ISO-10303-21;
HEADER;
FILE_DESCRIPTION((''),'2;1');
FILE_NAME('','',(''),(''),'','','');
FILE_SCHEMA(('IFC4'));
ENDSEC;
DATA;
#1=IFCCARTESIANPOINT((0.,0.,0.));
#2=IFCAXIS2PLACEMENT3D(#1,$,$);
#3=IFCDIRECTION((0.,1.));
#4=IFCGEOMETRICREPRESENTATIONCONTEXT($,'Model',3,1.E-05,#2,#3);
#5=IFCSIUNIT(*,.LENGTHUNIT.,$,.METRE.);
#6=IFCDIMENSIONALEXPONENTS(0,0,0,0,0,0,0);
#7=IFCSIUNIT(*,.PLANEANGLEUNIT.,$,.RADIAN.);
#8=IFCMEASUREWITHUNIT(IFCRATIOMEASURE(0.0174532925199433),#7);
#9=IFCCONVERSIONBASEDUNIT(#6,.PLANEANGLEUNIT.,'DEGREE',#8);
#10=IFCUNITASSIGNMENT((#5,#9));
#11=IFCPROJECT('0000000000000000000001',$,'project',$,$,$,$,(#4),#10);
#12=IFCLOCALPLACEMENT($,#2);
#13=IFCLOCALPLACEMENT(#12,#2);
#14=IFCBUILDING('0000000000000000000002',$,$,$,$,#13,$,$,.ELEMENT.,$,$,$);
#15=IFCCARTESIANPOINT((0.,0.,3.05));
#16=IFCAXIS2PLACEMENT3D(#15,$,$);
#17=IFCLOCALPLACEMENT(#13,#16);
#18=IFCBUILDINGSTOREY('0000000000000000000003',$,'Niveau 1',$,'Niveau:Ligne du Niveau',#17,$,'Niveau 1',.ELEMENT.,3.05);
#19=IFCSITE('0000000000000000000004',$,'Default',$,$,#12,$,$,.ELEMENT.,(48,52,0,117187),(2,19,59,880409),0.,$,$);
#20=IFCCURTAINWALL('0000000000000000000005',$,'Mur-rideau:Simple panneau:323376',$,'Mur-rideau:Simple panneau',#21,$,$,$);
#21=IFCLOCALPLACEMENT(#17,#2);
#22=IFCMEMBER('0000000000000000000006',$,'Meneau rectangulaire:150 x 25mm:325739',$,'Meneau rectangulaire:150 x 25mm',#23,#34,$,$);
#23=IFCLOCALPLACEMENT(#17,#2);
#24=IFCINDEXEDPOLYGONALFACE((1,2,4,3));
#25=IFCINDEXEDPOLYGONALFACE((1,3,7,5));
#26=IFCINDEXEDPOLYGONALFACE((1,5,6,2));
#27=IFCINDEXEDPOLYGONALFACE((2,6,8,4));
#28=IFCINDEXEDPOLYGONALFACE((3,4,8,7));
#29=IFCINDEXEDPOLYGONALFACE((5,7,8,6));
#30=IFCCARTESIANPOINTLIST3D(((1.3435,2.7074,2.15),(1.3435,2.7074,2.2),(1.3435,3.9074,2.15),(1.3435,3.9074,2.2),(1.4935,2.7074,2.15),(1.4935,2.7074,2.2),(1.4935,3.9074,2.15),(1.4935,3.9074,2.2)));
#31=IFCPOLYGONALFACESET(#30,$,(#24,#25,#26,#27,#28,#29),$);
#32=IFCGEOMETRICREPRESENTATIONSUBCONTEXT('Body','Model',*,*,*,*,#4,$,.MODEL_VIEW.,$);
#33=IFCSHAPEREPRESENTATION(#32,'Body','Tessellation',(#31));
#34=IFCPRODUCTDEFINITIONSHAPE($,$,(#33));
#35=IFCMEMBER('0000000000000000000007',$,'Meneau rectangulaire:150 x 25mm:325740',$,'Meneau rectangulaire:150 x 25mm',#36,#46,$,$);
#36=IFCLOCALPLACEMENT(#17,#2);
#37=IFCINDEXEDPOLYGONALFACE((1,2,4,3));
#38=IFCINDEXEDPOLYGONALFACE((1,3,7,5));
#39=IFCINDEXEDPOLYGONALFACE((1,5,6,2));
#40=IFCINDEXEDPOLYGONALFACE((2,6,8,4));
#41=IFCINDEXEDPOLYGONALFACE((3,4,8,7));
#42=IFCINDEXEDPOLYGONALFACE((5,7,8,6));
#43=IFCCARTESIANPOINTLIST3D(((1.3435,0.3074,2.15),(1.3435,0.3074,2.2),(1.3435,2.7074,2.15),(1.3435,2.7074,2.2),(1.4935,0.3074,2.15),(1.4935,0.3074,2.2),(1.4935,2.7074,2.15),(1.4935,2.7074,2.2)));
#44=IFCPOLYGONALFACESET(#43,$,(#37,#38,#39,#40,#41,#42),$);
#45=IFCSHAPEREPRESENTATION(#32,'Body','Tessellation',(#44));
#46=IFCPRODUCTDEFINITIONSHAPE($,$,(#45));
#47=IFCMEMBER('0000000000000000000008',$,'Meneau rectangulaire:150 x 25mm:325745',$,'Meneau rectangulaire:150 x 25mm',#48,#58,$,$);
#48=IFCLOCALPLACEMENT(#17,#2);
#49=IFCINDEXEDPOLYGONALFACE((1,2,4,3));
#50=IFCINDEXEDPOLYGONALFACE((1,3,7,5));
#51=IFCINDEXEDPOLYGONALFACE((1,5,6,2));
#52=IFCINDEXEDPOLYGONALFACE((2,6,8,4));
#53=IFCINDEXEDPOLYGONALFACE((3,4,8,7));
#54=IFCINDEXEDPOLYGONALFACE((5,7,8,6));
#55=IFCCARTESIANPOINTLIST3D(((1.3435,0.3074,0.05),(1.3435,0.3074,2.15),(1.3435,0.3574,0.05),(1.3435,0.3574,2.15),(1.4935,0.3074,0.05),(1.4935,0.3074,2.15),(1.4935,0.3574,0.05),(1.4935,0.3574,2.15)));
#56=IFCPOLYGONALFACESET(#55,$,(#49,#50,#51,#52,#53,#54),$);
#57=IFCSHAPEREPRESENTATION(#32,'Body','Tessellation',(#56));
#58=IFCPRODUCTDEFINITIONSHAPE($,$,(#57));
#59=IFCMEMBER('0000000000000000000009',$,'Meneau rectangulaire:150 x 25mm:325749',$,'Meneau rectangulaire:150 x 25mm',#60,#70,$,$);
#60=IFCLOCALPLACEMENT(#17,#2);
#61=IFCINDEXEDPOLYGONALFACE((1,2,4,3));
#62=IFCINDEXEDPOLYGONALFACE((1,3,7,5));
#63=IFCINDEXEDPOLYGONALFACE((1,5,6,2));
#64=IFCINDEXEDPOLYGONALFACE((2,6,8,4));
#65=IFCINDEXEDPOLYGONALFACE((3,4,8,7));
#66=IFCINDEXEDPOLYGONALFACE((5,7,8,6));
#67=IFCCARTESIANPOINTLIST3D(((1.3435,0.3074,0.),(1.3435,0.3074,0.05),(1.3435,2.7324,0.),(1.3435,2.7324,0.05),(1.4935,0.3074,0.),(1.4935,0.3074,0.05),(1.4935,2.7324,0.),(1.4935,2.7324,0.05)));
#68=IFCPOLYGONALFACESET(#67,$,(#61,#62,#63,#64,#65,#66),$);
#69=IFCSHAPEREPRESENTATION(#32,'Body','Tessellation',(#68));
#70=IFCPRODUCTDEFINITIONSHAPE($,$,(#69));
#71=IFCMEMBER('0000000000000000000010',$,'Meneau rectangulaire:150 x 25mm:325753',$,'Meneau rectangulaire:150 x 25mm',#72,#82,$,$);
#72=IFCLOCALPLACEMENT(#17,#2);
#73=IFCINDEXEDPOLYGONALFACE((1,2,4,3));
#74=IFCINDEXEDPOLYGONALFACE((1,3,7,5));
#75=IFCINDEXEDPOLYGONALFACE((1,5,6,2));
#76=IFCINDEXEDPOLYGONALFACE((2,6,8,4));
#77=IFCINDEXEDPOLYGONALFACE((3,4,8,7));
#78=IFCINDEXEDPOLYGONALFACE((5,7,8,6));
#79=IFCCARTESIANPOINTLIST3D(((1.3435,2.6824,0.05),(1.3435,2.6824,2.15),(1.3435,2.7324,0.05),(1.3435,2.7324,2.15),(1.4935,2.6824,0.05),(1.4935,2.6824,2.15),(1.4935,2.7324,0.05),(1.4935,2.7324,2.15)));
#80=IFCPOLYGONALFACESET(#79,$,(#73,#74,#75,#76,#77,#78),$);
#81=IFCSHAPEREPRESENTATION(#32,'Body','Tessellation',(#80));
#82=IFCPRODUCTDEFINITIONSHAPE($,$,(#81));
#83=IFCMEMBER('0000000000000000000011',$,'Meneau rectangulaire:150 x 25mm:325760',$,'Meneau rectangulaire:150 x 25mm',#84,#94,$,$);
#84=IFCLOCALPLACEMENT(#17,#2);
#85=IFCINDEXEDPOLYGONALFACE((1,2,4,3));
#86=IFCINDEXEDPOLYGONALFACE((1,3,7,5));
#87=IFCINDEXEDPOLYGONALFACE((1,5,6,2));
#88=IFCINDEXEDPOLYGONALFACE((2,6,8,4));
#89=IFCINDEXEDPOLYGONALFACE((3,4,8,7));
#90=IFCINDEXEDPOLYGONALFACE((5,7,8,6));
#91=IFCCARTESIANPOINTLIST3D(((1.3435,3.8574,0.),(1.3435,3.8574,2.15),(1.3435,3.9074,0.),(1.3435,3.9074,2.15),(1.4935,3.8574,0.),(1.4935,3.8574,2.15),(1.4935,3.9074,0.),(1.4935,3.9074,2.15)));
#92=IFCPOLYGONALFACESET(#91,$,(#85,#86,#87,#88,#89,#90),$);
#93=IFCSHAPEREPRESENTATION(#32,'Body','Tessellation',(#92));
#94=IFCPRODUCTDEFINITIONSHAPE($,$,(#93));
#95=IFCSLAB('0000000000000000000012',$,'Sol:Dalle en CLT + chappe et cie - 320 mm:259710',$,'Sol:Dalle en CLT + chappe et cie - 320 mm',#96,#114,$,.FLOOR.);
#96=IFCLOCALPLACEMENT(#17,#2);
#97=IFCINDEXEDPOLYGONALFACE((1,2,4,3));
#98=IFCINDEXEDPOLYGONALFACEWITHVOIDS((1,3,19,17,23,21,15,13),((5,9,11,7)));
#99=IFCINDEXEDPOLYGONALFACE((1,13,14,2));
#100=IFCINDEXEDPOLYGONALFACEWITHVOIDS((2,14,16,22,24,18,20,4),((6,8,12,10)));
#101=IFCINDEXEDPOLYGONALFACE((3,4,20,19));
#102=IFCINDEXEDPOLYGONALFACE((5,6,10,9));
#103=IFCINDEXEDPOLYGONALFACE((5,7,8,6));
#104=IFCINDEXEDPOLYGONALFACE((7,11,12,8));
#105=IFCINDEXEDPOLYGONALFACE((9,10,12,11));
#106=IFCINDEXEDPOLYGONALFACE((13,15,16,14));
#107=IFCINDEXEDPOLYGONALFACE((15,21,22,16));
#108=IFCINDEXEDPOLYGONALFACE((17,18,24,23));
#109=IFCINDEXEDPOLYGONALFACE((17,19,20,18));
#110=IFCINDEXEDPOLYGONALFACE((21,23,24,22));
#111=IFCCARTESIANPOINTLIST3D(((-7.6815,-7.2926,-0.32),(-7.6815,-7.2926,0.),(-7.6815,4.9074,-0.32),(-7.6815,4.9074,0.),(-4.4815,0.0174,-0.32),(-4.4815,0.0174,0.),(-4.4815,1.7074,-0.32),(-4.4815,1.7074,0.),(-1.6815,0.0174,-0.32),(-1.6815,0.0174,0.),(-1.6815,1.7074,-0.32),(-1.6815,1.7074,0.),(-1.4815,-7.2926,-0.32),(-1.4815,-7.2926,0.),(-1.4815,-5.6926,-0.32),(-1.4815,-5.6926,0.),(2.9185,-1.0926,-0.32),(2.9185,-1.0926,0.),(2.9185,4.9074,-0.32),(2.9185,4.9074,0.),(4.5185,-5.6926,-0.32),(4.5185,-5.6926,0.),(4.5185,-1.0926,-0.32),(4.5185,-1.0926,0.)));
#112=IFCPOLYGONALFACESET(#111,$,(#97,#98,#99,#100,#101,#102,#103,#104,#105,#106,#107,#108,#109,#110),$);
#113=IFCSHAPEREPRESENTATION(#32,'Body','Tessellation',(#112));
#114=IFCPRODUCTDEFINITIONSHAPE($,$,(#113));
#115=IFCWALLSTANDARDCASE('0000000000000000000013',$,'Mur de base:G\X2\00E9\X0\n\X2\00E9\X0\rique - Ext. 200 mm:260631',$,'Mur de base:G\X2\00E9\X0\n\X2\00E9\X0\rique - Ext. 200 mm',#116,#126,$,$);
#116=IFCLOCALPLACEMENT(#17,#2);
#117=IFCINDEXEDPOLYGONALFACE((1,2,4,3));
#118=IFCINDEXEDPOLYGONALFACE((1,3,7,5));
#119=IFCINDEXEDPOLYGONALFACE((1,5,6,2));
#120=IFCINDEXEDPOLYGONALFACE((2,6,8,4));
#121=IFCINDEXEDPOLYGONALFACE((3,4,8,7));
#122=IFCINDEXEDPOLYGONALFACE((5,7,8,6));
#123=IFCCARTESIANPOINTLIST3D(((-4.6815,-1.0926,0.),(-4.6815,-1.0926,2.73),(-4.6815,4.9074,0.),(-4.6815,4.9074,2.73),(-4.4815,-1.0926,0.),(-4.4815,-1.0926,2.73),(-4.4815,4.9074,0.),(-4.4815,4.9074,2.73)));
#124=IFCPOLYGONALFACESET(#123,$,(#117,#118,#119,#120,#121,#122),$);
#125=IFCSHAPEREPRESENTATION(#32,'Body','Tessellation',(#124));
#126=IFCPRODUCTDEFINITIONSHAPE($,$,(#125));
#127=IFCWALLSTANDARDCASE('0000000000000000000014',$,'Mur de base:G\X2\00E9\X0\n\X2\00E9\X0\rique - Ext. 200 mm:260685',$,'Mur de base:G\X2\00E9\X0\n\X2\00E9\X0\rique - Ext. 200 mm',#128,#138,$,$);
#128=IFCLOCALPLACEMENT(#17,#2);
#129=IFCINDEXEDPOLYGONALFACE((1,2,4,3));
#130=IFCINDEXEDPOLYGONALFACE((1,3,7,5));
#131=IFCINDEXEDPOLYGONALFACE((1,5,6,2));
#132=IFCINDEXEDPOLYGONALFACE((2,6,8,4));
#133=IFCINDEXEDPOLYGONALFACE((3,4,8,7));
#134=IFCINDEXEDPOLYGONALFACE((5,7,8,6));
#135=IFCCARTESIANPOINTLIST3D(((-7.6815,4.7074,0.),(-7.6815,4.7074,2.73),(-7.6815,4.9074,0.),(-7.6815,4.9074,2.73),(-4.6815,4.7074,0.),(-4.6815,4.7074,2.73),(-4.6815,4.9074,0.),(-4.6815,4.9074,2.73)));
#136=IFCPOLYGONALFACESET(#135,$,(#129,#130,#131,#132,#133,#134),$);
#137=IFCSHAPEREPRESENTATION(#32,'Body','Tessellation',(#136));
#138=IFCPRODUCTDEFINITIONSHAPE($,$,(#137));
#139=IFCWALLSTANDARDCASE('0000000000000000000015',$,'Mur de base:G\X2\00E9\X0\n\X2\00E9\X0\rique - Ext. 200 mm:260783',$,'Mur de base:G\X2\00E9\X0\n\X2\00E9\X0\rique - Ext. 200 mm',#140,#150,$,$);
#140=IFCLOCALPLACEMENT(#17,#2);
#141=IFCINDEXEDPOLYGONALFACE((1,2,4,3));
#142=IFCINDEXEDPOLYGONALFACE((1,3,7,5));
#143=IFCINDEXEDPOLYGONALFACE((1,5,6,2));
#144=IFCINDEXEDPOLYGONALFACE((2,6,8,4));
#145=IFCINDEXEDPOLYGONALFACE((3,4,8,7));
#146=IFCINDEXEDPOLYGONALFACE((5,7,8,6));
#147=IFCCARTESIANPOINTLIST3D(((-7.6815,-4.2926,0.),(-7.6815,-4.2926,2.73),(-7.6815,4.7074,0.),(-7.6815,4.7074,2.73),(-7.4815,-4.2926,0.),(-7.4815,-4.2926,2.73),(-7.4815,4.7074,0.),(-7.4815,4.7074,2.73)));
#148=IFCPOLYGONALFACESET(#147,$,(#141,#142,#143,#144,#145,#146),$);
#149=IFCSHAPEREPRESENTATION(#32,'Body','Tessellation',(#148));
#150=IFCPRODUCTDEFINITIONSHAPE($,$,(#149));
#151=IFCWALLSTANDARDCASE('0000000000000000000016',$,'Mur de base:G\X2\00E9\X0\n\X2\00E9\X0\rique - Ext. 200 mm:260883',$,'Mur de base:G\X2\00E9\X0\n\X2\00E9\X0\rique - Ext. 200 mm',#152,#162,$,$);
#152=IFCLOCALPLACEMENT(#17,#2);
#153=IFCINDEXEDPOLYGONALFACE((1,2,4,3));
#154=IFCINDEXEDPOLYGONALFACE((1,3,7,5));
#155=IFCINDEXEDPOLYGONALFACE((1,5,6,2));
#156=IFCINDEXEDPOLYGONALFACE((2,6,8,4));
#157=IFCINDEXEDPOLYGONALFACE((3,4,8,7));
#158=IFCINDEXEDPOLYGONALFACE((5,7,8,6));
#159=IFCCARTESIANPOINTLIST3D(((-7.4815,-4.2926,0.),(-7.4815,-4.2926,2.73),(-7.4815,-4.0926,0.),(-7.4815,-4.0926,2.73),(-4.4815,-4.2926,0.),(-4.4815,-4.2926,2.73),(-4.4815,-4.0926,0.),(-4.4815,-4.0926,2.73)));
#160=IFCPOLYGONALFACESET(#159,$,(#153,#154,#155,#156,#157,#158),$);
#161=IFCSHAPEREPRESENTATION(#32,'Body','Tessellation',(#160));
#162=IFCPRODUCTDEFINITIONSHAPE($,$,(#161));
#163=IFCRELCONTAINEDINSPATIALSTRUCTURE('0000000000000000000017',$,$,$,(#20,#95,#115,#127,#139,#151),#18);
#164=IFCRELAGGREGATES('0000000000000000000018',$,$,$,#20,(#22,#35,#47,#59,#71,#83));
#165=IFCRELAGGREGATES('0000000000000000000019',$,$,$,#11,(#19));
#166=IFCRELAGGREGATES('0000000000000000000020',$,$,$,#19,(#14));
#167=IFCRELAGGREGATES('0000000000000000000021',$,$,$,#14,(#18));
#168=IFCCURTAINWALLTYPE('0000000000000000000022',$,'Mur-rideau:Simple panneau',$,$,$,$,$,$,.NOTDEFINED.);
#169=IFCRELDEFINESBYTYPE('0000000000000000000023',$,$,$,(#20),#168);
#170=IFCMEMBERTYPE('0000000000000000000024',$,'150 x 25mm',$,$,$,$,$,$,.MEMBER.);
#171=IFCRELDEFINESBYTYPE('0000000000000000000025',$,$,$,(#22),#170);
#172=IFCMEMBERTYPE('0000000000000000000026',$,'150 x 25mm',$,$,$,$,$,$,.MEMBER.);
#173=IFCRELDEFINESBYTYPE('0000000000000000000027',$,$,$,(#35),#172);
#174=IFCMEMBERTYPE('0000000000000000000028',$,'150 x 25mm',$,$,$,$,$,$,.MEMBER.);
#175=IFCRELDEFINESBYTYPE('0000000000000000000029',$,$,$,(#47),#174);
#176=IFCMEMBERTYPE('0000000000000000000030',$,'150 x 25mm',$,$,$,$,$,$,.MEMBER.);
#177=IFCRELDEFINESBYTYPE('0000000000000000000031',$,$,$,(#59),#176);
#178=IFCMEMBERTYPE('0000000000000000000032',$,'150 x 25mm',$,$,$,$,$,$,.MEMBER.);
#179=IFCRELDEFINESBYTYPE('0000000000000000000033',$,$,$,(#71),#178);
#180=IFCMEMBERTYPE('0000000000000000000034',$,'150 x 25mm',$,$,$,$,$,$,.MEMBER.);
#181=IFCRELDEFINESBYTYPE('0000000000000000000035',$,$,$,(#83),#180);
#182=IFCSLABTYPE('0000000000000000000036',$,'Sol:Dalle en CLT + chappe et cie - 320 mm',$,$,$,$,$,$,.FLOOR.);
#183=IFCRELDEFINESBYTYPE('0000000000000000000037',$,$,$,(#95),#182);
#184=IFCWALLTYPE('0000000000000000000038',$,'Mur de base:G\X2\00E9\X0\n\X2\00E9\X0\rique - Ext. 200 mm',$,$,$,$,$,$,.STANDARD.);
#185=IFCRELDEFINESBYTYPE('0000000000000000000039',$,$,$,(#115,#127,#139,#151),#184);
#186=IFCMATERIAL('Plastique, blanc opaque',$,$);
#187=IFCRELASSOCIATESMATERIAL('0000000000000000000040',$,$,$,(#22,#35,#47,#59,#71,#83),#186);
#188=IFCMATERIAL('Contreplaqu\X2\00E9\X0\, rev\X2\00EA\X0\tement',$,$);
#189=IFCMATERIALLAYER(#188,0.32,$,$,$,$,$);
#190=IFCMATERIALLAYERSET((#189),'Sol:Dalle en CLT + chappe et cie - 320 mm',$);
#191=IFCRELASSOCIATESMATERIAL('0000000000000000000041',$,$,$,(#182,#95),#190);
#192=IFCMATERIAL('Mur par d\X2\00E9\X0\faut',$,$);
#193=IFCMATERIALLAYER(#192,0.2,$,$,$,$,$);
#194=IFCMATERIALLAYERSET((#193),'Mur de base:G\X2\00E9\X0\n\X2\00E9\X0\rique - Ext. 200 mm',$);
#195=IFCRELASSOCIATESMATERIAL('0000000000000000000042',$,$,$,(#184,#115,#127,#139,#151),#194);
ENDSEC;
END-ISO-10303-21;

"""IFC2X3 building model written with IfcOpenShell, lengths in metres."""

from ifc_helpers import new_model, entity, si_unit, converted_unit, direction, frame, frame_2d, origin, origin_2d_with_axis, place, context, subcontext, project, spatial, polyline, rectangle, outline, extrude, clip, bounded_halfspace, source, transform, mapped, material, layer, layer_set, layer_usage, type_object, type_shapes, element, aggregate, save


model = new_model("IFC2X3")

# Units and contexts
model_context = context("Model", 3, precision=1e-05, world=origin(), true_north=direction((0.0, 1.0)))
body_context = subcontext(model_context, "Body", "Model", "MODEL_VIEW")
ifc_project = project(units=[si_unit("LENGTHUNIT", "METRE"), converted_unit("PLANEANGLEUNIT", "DEGREE", entity("IfcRatioMeasure", 0.0174532925199433), si_unit("PLANEANGLEUNIT", "RADIAN"), dimensions=[0, 0, 0, 0, 0, 0, 0])], contexts=[model_context])

# Site, building, storey
site_placement = place(None, origin())
site = spatial("IfcSite", under=ifc_project, at=site_placement, Name="Default", CompositionType="ELEMENT", RefLatitude=(48, 52, 0, 117187), RefLongitude=(2, 19, 59, 880409), RefElevation=0.0)
building_placement = place(site_placement, origin())
building = spatial("IfcBuilding", under=site, at=building_placement, CompositionType="ELEMENT")
storey_placement = place(building_placement, frame((0.0, 0.0, 3.05)))
storey = spatial("IfcBuildingStorey", under=building, at=storey_placement, Name="Niveau 1", ObjectType="Niveau:Ligne du Niveau", LongName="Niveau 1", CompositionType="ELEMENT", Elevation=3.05)

# Curtain wall, members
curtain_wall_type = type_object("IfcCurtainWallType", Name="Mur-rideau:Simple panneau", PredefinedType="NOTDEFINED")
curtain_wall_placement = place(storey_placement, frame((0.0, 0.0, -3.05)))
curtain_wall = element("IfcCurtainWall", 1, at=curtain_wall_placement, inside=storey, type_object=curtain_wall_type, Name="Mur-rideau:Simple panneau:323376", ObjectType="Mur-rideau:Simple panneau")
ifc_material_1 = material(Name="Plastique, blanc opaque")
member_type_1 = type_object("IfcMemberType", Name="150 x 25mm", PredefinedType="MEMBER")
shared_shape_1 = source(origin(), body_context, "Body", "SweptSolid", [
    extrude(rectangle(XDim=0.15, YDim=0.05, at=origin_2d_with_axis()), frame((-0.025, 0.0, -1.2), z_axis=(0.0, 0.0, 1.0), x_axis=(0.0, -1.0, 0.0)), (0.0, 0.0, 1.0), 1.2),
])
type_shapes(member_type_1, [shared_shape_1])
member_1_placement = place(storey_placement, frame((1.4185, 2.7074, 2.2), z_axis=(0.0, -1.0, 0.0), x_axis=(0.0, 0.0, 1.0)))
member_1 = element("IfcMember", 2, at=member_1_placement, type_object=member_type_1, material=ifc_material_1, Name="Meneau rectangulaire:150 x 25mm:325739", ObjectType="Meneau rectangulaire:150 x 25mm", context=body_context, shape_type="MappedRepresentation", body=[
    mapped(shared_shape_1, transform((0.0, 0.0, 0.0), scale=1.0)),
])
member_type_2 = type_object("IfcMemberType", Name="150 x 25mm", PredefinedType="MEMBER")
shared_shape_2 = source(origin(), body_context, "Body", "SweptSolid", [
    extrude(rectangle(XDim=0.15, YDim=0.05, at=origin_2d_with_axis()), frame((-0.025, 0.0, -2.4), z_axis=(0.0, 0.0, 1.0), x_axis=(0.0, -1.0, 0.0)), (0.0, 0.0, 1.0), 2.4),
])
type_shapes(member_type_2, [shared_shape_2])
member_2_placement = place(storey_placement, frame((1.4185, 0.3074, 2.2), z_axis=(0.0, -1.0, 0.0), x_axis=(0.0, 0.0, 1.0)))
member_2 = element("IfcMember", 3, at=member_2_placement, type_object=member_type_2, material=ifc_material_1, Name="Meneau rectangulaire:150 x 25mm:325740", ObjectType="Meneau rectangulaire:150 x 25mm", context=body_context, shape_type="MappedRepresentation", body=[
    mapped(shared_shape_2, transform((0.0, 0.0, 0.0), scale=1.0)),
])
member_type_3 = type_object("IfcMemberType", Name="150 x 25mm", PredefinedType="MEMBER")
shared_shape_3 = source(origin(), body_context, "Body", "SweptSolid", [
    extrude(rectangle(XDim=0.15, YDim=0.05, at=origin_2d_with_axis()), frame((-0.025, 0.0, -2.1), z_axis=(0.0, 0.0, 1.0), x_axis=(0.0, -1.0, 0.0)), (0.0, 0.0, 1.0), 2.1),
])
type_shapes(member_type_3, [shared_shape_3])
member_3_placement = place(storey_placement, frame((1.4185, 0.3074, 0.05), z_axis=(0.0, 0.0, -1.0), x_axis=(0.0, -1.0, 0.0)))
member_3 = element("IfcMember", 4, at=member_3_placement, type_object=member_type_3, material=ifc_material_1, Name="Meneau rectangulaire:150 x 25mm:325745", ObjectType="Meneau rectangulaire:150 x 25mm", context=body_context, shape_type="MappedRepresentation", body=[
    mapped(shared_shape_3, transform((0.0, 0.0, 0.0), scale=1.0)),
])
member_type_4 = type_object("IfcMemberType", Name="150 x 25mm", PredefinedType="MEMBER")
shared_shape_4 = source(origin(), body_context, "Body", "SweptSolid", [
    extrude(rectangle(XDim=0.15, YDim=0.05, at=origin_2d_with_axis()), frame((-0.025, 0.0, -2.425), z_axis=(0.0, 0.0, 1.0), x_axis=(0.0, -1.0, 0.0)), (0.0, 0.0, 1.0), 2.425),
])
type_shapes(member_type_4, [shared_shape_4])
member_4_placement = place(storey_placement, frame((1.4185, 2.7324, 0.0), z_axis=(0.0, 1.0, 0.0), x_axis=(0.0, 0.0, -1.0)))
member_4 = element("IfcMember", 5, at=member_4_placement, type_object=member_type_4, material=ifc_material_1, Name="Meneau rectangulaire:150 x 25mm:325749", ObjectType="Meneau rectangulaire:150 x 25mm", context=body_context, shape_type="MappedRepresentation", body=[
    mapped(shared_shape_4, transform((0.0, 0.0, 0.0), scale=1.0)),
])
member_type_5 = type_object("IfcMemberType", Name="150 x 25mm", PredefinedType="MEMBER")
shared_shape_5 = source(origin(), body_context, "Body", "SweptSolid", [
    extrude(rectangle(XDim=0.15, YDim=0.05, at=origin_2d_with_axis()), frame((0.0, 0.0, -2.1), z_axis=(0.0, 0.0, 1.0), x_axis=(0.0, -1.0, 0.0)), (0.0, 0.0, 1.0), 2.1),
])
type_shapes(member_type_5, [shared_shape_5])
member_5_placement = place(storey_placement, frame((1.4185, 2.7074, 0.05), z_axis=(0.0, 0.0, -1.0), x_axis=(0.0, -1.0, 0.0)))
member_5 = element("IfcMember", 6, at=member_5_placement, type_object=member_type_5, material=ifc_material_1, Name="Meneau rectangulaire:150 x 25mm:325753", ObjectType="Meneau rectangulaire:150 x 25mm", context=body_context, shape_type="MappedRepresentation", body=[
    mapped(shared_shape_5, transform((0.0, 0.0, 0.0), scale=1.0)),
])
member_type_6 = type_object("IfcMemberType", Name="150 x 25mm", PredefinedType="MEMBER")
shared_shape_6 = source(origin(), body_context, "Body", "SweptSolid", [
    extrude(rectangle(XDim=0.15, YDim=0.05, at=origin_2d_with_axis()), frame((-0.025, 0.0, -2.15), z_axis=(0.0, 0.0, 1.0), x_axis=(0.0, -1.0, 0.0)), (0.0, 0.0, 1.0), 2.15),
])
type_shapes(member_type_6, [shared_shape_6])
member_6_placement = place(storey_placement, frame((1.4185, 3.9074, 2.15), z_axis=(0.0, 0.0, 1.0), x_axis=(0.0, 1.0, 0.0)))
member_6 = element("IfcMember", 7, at=member_6_placement, type_object=member_type_6, material=ifc_material_1, Name="Meneau rectangulaire:150 x 25mm:325760", ObjectType="Meneau rectangulaire:150 x 25mm", context=body_context, shape_type="MappedRepresentation", body=[
    mapped(shared_shape_6, transform((0.0, 0.0, 0.0), scale=1.0)),
])

# Slab, opening
ifc_material_2 = material(Name="Contreplaqué, revêtement")
ifc_layer_1 = layer(ifc_material_2, 0.32)
ifc_layer_set_1 = layer_set([ifc_layer_1], Name="Sol:Dalle en CLT + chappe et cie - 320 mm")
ifc_layer_usage_1 = layer_usage(ifc_layer_set_1, "AXIS3", "POSITIVE", 0.0)
slab_type = type_object("IfcSlabType", Name="Sol:Dalle en CLT + chappe et cie - 320 mm", PredefinedType="FLOOR", material=ifc_layer_set_1)
slab_placement = place(storey_placement, frame((-7.6815, -7.2926, -0.32)))
slab = element("IfcSlab", 8, at=slab_placement, inside=storey, type_object=slab_type, material=ifc_layer_usage_1, Name="Sol:Dalle en CLT + chappe et cie - 320 mm:259710", ObjectType="Sol:Dalle en CLT + chappe et cie - 320 mm", PredefinedType="FLOOR", context=body_context, shape_type="SweptSolid", body=[
    extrude(outline(polyline([(6.1, -6.1), (6.1, 6.1), (-4.5, 6.1), (-4.5, 0.1), (-6.1, 0.1), (-6.1, -4.5), (-0.1, -4.5), (-0.1, -6.1), (6.1, -6.1)])), frame((6.1, 6.1, 0.32), z_axis=(0.0, 0.0, -1.0), x_axis=(-1.0, 0.0, 0.0)), (0.0, 0.0, 1.0), 0.32),
])
opening_1_placement = place(slab_placement, frame((4.6, 8.155, 0.32)))
element("IfcOpeningElement", 9, at=opening_1_placement, cuts=slab, ObjectType="Opening", context=body_context, shape_type="SweptSolid", body=[
    extrude(rectangle(XDim=2.8, YDim=1.69, at=origin_2d_with_axis()), origin(), (0.0, 0.0, -1.0), 0.32),
])

aggregate(curtain_wall, [member_1, member_2, member_3, member_4, member_5, member_6])

# Walls
ifc_material_3 = material(Name="Mur par défaut")
ifc_layer_2 = layer(ifc_material_3, 0.2)
ifc_layer_set_2 = layer_set([ifc_layer_2], Name="Mur de base:Générique - Ext. 200 mm")
ifc_layer_usage_2 = layer_usage(ifc_layer_set_2, "AXIS2", "NEGATIVE", 0.1)
wall_type = type_object("IfcWallType", Name="Mur de base:Générique - Ext. 200 mm", PredefinedType="STANDARD", material=ifc_layer_set_2)
wall_1_placement = place(storey_placement, frame((-4.5815, -1.0926, 0.0), z_axis=(0.0, 0.0, 1.0), x_axis=(0.0, 1.0, 0.0)))
element("IfcWallStandardCase", 10, at=wall_1_placement, inside=storey, type_object=wall_type, material=ifc_layer_usage_2, Name="Mur de base:Générique - Ext. 200 mm:260631", ObjectType="Mur de base:Générique - Ext. 200 mm", context=body_context, shape_type="Clipping", body=[
    clip(extrude(rectangle(XDim=6.0, YDim=0.2, at=frame_2d((3.0, 0.0), x_axis=(-1.0, 0.0))), origin(), (0.0, 0.0, 1.0), 2.73), bounded_halfspace(frame((0.0, -0.1, 2.73), z_axis=(0.0, 0.0, -1.0), x_axis=(0.0, -1.0, 0.0)), True, frame((0.0, -0.1, 2.73)), polyline([(0.0, 0.0), (2.8, 0.0), (3.0, 0.0), (6.0, 0.0), (6.0, 0.2), (5.8, 0.2), (0.0, 0.2), (0.0, 0.0)]))),
])
ifc_layer_usage_3 = layer_usage(ifc_layer_set_2, "AXIS2", "NEGATIVE", 0.1)
wall_2_placement = place(storey_placement, frame((-4.6815, 4.8074, 0.0), z_axis=(0.0, 0.0, 1.0), x_axis=(-1.0, 0.0, 0.0)))
element("IfcWallStandardCase", 11, at=wall_2_placement, inside=storey, type_object=wall_type, material=ifc_layer_usage_3, Name="Mur de base:Générique - Ext. 200 mm:260685", ObjectType="Mur de base:Générique - Ext. 200 mm", context=body_context, shape_type="Clipping", body=[
    clip(extrude(rectangle(XDim=3.0, YDim=0.2, at=frame_2d((1.5, 0.0), x_axis=(-1.0, 0.0))), origin(), (0.0, 0.0, 1.0), 2.73), bounded_halfspace(frame((0.0, -0.1, 2.73), z_axis=(0.0, 0.0, -1.0), x_axis=(-1.0, 0.0, 0.0)), True, frame((0.0, -0.1, 2.73)), polyline([(0.0, 0.0), (3.0, 0.0), (3.0, 0.2), (2.8, 0.2), (0.0, 0.2), (0.0, 0.0)]))),
])
ifc_layer_usage_4 = layer_usage(ifc_layer_set_2, "AXIS2", "NEGATIVE", 0.1)
wall_3_placement = place(storey_placement, frame((-7.5815, 4.7074, 0.0), z_axis=(0.0, 0.0, 1.0), x_axis=(0.0, -1.0, 0.0)))
element("IfcWallStandardCase", 12, at=wall_3_placement, inside=storey, type_object=wall_type, material=ifc_layer_usage_4, Name="Mur de base:Générique - Ext. 200 mm:260783", ObjectType="Mur de base:Générique - Ext. 200 mm", context=body_context, shape_type="Clipping", body=[
    clip(extrude(rectangle(XDim=9.0, YDim=0.2, at=frame_2d((4.5, 0.0), x_axis=(-1.0, 0.0))), origin(), (0.0, 0.0, 1.0), 2.73), bounded_halfspace(frame((0.0, -0.1, 2.73), z_axis=(0.0, 0.0, -1.0), x_axis=(0.0, 1.0, 0.0)), True, frame((0.0, -0.1, 2.73)), polyline([(0.0, 0.0), (9.0, 0.0), (9.0, 0.2), (8.8, 0.2), (6.0, 0.2), (5.8, 0.2), (0.0, 0.2), (0.0, 0.0)]))),
])
ifc_layer_usage_5 = layer_usage(ifc_layer_set_2, "AXIS2", "NEGATIVE", 0.1)
wall_4_placement = place(storey_placement, frame((-7.4815, -4.1926, 0.0)))
element("IfcWallStandardCase", 13, at=wall_4_placement, inside=storey, type_object=wall_type, material=ifc_layer_usage_5, Name="Mur de base:Générique - Ext. 200 mm:260883", ObjectType="Mur de base:Générique - Ext. 200 mm", context=body_context, shape_type="Clipping", body=[
    clip(extrude(rectangle(XDim=3.0, YDim=0.2, at=frame_2d((1.5, 0.0), x_axis=(-1.0, 0.0))), origin(), (0.0, 0.0, 1.0), 2.73), bounded_halfspace(frame((0.0, -0.1, 2.73), z_axis=(0.0, 0.0, -1.0), x_axis=(1.0, 0.0, 0.0)), True, frame((0.0, -0.1, 2.73)), polyline([(0.0, 0.0), (2.8, 0.0), (3.0, 0.0), (3.0, 0.2), (0.0, 0.2), (0.0, 0.0)]))),
])

save(model, "model.ifc")
